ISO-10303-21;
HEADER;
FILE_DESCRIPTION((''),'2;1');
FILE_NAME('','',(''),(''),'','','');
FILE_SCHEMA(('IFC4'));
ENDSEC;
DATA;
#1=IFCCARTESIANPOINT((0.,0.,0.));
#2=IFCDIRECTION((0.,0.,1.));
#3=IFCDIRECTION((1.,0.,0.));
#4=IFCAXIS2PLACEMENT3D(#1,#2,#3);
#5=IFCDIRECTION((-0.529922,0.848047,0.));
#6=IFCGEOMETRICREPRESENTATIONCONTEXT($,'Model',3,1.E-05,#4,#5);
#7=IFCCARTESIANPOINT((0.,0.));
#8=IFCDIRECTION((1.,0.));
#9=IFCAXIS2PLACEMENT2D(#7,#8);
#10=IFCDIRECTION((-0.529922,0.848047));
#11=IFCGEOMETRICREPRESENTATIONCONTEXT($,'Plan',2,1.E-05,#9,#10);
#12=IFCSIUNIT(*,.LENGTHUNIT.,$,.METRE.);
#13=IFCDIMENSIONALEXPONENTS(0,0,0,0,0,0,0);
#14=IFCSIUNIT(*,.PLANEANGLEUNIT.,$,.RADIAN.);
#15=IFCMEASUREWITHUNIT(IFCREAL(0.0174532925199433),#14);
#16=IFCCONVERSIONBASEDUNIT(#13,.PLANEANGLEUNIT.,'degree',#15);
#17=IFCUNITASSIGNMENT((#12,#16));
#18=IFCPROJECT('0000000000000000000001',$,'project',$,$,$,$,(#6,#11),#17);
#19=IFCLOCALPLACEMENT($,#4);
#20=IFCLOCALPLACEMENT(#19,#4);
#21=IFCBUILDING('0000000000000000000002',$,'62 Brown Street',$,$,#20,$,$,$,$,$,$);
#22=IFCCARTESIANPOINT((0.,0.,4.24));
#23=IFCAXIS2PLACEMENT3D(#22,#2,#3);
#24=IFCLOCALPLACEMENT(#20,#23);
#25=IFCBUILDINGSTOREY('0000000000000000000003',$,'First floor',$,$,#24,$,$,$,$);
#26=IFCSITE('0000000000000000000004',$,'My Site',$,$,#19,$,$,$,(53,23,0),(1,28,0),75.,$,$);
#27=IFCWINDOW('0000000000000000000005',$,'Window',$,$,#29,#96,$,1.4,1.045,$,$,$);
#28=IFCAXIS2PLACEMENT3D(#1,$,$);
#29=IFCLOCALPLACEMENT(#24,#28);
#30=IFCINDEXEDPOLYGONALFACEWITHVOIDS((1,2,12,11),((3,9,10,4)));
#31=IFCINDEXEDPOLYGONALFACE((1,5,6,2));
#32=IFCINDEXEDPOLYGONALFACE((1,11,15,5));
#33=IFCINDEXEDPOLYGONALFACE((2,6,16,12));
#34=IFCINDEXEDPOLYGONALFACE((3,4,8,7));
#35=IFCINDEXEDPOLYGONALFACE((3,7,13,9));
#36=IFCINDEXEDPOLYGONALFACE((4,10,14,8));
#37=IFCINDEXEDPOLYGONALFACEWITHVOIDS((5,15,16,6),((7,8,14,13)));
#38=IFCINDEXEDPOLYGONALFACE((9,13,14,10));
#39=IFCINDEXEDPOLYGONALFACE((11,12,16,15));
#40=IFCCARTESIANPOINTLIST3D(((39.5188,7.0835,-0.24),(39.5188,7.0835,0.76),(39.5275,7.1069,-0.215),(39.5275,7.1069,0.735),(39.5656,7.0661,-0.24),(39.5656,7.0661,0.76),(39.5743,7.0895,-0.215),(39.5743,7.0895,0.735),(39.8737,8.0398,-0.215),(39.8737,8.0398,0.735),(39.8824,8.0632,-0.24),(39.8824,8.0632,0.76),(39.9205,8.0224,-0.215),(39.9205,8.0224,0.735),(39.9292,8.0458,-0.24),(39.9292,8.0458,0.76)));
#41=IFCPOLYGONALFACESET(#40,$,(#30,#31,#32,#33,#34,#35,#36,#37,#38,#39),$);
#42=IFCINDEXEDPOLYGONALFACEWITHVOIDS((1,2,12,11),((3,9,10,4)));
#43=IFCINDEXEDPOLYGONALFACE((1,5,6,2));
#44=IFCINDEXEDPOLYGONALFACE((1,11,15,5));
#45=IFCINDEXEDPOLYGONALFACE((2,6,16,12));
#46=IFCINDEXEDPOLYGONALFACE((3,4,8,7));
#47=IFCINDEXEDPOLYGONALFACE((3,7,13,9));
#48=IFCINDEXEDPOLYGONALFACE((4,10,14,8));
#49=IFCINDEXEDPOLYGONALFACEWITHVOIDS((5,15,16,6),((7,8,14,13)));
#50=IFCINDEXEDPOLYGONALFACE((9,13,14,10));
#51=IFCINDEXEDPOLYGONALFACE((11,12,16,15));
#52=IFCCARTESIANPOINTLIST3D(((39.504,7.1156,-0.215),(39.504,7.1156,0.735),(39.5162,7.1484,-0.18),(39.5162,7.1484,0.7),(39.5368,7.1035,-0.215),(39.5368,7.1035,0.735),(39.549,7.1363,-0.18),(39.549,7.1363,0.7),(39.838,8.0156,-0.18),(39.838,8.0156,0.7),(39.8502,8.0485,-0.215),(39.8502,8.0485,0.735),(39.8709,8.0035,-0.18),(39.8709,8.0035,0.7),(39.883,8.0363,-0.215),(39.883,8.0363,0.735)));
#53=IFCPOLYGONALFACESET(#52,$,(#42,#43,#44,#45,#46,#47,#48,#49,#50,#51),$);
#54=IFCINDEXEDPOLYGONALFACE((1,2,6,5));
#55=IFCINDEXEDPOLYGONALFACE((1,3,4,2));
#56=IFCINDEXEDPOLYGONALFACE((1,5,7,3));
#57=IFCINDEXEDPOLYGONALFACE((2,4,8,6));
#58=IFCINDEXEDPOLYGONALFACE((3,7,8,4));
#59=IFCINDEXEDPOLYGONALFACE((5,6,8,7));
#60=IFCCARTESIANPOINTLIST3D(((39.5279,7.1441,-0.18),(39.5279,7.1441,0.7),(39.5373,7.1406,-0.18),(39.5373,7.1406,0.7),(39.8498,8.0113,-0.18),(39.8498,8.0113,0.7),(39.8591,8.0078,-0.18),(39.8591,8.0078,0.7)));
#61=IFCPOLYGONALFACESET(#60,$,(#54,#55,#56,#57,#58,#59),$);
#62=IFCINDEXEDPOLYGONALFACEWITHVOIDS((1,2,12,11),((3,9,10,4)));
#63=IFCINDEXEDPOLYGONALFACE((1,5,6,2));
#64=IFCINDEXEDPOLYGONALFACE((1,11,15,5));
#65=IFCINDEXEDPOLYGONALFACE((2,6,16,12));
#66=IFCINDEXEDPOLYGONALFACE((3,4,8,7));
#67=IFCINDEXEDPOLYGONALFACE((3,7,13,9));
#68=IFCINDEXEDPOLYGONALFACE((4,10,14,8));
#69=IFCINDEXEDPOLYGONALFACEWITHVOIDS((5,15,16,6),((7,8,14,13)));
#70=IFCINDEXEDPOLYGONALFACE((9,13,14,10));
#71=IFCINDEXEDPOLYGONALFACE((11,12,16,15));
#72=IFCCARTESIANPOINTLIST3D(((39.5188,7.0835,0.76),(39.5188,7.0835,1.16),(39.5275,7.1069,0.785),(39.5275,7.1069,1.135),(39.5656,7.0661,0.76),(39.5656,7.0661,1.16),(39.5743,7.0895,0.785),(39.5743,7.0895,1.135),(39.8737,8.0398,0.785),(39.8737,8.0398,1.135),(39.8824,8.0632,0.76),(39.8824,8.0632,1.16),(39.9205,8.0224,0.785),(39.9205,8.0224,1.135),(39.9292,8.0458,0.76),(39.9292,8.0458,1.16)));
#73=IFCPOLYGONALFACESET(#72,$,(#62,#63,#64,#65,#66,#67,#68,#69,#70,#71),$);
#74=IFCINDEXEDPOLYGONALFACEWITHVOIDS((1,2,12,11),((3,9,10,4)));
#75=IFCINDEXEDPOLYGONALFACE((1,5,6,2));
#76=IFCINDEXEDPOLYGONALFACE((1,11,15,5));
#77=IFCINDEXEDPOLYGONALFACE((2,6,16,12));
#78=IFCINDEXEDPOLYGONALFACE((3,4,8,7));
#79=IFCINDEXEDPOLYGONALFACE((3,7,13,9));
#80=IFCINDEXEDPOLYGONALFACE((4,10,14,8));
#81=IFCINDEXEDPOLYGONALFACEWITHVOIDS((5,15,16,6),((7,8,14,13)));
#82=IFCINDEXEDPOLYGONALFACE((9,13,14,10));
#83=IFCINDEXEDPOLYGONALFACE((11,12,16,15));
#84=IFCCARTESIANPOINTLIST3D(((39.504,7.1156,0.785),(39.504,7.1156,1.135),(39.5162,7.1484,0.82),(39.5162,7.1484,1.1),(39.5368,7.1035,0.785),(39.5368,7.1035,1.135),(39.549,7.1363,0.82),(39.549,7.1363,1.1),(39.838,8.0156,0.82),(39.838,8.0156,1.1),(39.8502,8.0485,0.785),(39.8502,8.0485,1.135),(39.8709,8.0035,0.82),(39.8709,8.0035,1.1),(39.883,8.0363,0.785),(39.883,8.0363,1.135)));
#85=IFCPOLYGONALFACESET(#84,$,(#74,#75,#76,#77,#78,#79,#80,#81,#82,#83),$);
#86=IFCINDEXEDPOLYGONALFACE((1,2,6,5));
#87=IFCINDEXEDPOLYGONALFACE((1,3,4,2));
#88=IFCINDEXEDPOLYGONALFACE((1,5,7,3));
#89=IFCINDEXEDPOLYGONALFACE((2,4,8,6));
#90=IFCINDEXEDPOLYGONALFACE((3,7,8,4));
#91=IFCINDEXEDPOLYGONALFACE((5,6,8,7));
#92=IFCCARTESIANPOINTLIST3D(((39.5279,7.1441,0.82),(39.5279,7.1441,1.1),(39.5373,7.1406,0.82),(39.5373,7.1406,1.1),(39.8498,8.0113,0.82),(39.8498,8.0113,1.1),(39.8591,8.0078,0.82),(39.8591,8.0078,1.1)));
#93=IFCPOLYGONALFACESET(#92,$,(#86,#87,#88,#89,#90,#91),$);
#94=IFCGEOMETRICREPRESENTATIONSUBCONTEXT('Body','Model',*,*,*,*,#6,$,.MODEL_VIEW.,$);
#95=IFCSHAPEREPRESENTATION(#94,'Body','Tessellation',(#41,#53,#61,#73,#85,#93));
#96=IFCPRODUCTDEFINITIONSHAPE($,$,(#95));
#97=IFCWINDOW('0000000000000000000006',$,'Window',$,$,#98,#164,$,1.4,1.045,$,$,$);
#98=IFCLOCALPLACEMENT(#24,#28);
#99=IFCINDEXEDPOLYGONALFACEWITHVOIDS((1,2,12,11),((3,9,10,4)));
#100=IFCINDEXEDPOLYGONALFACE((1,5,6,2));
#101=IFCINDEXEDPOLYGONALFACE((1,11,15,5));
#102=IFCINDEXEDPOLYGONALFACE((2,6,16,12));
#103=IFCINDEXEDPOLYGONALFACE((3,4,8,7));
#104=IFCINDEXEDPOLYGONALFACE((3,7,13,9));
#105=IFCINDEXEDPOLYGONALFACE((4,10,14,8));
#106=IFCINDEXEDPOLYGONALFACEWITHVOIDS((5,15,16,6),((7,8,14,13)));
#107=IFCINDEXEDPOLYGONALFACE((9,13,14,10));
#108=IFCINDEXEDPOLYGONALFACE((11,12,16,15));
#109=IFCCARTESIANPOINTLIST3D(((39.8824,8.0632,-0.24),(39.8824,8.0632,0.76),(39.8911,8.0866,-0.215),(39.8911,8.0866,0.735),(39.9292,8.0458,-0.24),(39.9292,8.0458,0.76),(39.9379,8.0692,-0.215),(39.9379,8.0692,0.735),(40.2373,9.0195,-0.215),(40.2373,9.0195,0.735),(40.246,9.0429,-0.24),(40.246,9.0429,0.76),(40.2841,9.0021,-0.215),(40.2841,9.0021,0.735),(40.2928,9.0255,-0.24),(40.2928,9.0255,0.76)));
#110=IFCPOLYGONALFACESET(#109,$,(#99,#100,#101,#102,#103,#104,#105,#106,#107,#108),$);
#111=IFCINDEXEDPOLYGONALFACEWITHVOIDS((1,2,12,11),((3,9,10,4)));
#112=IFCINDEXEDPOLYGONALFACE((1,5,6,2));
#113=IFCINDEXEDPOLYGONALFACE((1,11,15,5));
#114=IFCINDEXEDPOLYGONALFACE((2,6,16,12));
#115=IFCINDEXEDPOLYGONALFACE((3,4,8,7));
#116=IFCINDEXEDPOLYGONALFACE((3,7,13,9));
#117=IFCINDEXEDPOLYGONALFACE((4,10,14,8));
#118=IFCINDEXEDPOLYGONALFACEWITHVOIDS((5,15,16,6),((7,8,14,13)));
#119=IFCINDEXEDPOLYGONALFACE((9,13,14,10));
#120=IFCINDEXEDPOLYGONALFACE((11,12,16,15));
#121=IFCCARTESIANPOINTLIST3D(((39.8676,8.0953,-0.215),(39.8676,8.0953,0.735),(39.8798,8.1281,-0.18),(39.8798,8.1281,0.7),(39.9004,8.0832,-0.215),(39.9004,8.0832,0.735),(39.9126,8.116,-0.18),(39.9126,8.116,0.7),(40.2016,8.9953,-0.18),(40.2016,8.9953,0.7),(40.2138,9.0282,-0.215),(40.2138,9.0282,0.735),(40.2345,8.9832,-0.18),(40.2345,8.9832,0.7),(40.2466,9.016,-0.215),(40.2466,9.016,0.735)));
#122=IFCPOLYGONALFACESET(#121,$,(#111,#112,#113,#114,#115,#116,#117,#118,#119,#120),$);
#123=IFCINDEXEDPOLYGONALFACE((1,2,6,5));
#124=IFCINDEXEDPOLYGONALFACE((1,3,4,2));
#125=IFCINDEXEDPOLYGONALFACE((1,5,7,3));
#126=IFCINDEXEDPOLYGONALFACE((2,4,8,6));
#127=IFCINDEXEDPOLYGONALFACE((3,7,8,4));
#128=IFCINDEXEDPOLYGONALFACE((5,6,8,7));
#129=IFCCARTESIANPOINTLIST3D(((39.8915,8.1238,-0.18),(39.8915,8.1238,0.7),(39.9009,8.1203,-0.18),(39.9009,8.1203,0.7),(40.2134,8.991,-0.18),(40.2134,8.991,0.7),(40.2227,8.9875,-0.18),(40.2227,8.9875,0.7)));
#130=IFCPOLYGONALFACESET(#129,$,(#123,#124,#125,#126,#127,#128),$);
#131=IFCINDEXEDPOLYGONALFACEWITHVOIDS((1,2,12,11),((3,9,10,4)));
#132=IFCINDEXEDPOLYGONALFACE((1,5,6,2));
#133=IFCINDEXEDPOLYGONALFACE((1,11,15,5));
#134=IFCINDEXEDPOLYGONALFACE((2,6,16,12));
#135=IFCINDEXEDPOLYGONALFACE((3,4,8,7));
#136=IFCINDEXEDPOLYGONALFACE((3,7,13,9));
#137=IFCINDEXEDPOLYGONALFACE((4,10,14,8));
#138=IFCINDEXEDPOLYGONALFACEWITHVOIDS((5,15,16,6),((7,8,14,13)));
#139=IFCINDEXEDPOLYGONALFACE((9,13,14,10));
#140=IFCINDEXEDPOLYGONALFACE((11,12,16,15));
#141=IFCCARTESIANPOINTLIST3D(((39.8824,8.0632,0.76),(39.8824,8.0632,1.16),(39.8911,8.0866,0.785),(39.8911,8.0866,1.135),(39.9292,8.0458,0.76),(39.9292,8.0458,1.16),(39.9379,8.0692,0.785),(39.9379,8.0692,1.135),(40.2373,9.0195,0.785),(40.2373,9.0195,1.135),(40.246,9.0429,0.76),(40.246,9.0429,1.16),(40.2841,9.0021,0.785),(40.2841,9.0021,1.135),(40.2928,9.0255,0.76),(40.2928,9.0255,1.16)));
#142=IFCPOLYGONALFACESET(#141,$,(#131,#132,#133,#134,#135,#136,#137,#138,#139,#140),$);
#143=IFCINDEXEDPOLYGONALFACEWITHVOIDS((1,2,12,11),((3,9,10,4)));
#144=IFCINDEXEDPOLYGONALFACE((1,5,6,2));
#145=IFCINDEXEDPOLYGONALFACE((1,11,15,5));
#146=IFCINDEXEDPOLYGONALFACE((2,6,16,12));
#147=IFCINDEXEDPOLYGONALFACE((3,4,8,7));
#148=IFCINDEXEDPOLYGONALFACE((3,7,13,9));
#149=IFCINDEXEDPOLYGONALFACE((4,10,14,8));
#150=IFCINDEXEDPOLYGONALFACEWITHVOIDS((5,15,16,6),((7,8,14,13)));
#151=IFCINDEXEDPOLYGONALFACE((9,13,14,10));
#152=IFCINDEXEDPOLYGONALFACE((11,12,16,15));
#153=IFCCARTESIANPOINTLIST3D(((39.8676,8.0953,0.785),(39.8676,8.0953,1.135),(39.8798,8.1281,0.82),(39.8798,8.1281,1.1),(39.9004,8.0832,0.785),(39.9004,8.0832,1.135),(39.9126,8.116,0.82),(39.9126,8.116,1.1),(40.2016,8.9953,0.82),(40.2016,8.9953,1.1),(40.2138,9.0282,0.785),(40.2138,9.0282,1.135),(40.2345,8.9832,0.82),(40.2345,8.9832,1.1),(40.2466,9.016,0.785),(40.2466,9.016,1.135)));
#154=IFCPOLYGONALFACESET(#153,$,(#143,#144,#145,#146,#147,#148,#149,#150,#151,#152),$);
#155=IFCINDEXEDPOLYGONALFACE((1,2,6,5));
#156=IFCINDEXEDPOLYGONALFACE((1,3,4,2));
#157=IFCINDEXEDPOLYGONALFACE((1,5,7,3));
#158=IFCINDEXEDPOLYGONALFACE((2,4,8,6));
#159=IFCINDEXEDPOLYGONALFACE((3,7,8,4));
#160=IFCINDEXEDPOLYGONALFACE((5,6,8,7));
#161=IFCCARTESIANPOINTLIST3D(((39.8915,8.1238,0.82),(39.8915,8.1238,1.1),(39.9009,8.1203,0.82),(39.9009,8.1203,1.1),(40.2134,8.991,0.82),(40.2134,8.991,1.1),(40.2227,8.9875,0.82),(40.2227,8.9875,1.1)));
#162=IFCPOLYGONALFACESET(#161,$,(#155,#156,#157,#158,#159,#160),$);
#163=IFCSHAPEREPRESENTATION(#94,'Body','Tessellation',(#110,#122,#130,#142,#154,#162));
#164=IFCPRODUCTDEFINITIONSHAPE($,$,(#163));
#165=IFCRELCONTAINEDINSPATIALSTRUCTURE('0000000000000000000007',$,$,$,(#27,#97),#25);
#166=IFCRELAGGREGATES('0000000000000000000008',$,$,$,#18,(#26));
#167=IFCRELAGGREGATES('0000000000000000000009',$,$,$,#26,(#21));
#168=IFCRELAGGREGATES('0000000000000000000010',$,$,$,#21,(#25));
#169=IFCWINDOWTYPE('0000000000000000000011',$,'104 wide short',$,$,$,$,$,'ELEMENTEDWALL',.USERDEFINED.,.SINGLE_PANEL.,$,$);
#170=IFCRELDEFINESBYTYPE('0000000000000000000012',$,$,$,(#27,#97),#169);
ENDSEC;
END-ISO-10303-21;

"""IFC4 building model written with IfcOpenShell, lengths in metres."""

from ifc_helpers import new_model, entity, si_unit, converted_unit, direction, frame, origin_with_axes, origin_2d_with_axis, place, context, subcontext, project, spatial, line, indexed_curve, outline, extrude, shape, source, transform, mapped, type_object, type_shapes, element, save


model = new_model("IFC4")

# Units and contexts
model_context = context("Model", 3, precision=1e-05, world=origin_with_axes(), true_north=direction((-0.529922, 0.848047, 0.0)))
plan_context = context("Plan", 2, precision=1e-05, world=origin_2d_with_axis(), true_north=direction((-0.529922, 0.848047)))
body_context_1 = subcontext(model_context, "Body", "Model", "MODEL_VIEW")
body_context_2 = subcontext(plan_context, "Body", "Plan", "PLAN_VIEW")
ifc_project = project(units=[si_unit("LENGTHUNIT", "METRE"), converted_unit("PLANEANGLEUNIT", "degree", entity("IfcReal", 0.0174532925199433), si_unit("PLANEANGLEUNIT", "RADIAN"), dimensions=[0, 0, 0, 0, 0, 0, 0])], contexts=[model_context, plan_context])

# Site, building, storey
site_placement = place(None, origin_with_axes())
site = spatial("IfcSite", under=ifc_project, at=site_placement, Name="My Site", RefLatitude=(53, 23, 0), RefLongitude=(1, 28, 0), RefElevation=75.0)
building_placement = place(site_placement, origin_with_axes())
building = spatial("IfcBuilding", under=site, at=building_placement, Name="62 Brown Street")
storey_placement = place(building_placement, frame((0.0, 0.0, 4.24), z_axis=(0.0, 0.0, 1.0), x_axis=(1.0, 0.0, 0.0)))
storey = spatial("IfcBuildingStorey", under=building, at=storey_placement, Name="First floor")

# Shared definitions
window_type = type_object("IfcWindowType", Name="104 wide short", ElementType="ELEMENTEDWALL", PartitioningType="SINGLE_PANEL", PredefinedType="USERDEFINED")
shared_shape_1 = source(origin_with_axes(), body_context_1, "Body", "SweptSolid", [
    extrude(outline(indexed_curve([(0.0, 0.0), (1.045, 0.0), (1.045, 1.0), (0.0, 1.0)], segments=[line(1, 2, 3, 4, 1)]), holes=[indexed_curve([(0.025, 0.025), (1.02, 0.025), (1.02, 0.975), (0.025, 0.975)], segments=[line(1, 2, 3, 4, 1)])]), frame((0.0, 0.15, 0.0), z_axis=(0.0, -1.0, 0.0), x_axis=(1.0, 0.0, 0.0)), (0.0, 0.0, -1.0), 0.05),
    extrude(outline(indexed_curve([(0.0, 0.0), (0.995, 0.0), (0.995, 0.95), (0.0, 0.95)], segments=[line(1, 2, 3, 4, 1)]), holes=[indexed_curve([(0.035, 0.035), (0.96, 0.035), (0.96, 0.915), (0.035, 0.915)], segments=[line(1, 2, 3, 4, 1)])]), frame((0.025, 0.19, 0.025), z_axis=(0.0, -1.0, 0.0), x_axis=(1.0, 0.0, 0.0)), (0.0, 0.0, -1.0), 0.035),
    extrude(outline(indexed_curve([(0.035, 0.035), (0.96, 0.035), (0.96, 0.915), (0.035, 0.915)], segments=[line(1, 2, 3, 4, 1)])), frame((0.025, 0.2025, 0.025), z_axis=(0.0, -1.0, 0.0), x_axis=(1.0, 0.0, 0.0)), (0.0, 0.0, -1.0), 0.01),
    extrude(outline(indexed_curve([(0.0, 0.0), (1.045, 0.0), (1.045, 0.4), (0.0, 0.4)], segments=[line(1, 2, 3, 4, 1)]), holes=[indexed_curve([(0.025, 0.025), (1.02, 0.025), (1.02, 0.375), (0.025, 0.375)], segments=[line(1, 2, 3, 4, 1)])]), frame((0.0, 0.15, 1.0), z_axis=(0.0, -1.0, 0.0), x_axis=(1.0, 0.0, 0.0)), (0.0, 0.0, -1.0), 0.05),
    extrude(outline(indexed_curve([(0.0, 0.0), (0.995, 0.0), (0.995, 0.35), (0.0, 0.35)], segments=[line(1, 2, 3, 4, 1)]), holes=[indexed_curve([(0.035, 0.035), (0.96, 0.035), (0.96, 0.315), (0.035, 0.315)], segments=[line(1, 2, 3, 4, 1)])]), frame((0.025, 0.19, 1.025), z_axis=(0.0, -1.0, 0.0), x_axis=(1.0, 0.0, 0.0)), (0.0, 0.0, -1.0), 0.035),
    extrude(outline(indexed_curve([(0.035, 0.035), (0.96, 0.035), (0.96, 0.315), (0.035, 0.315)], segments=[line(1, 2, 3, 4, 1)])), frame((0.025, 0.2025, 1.025), z_axis=(0.0, -1.0, 0.0), x_axis=(1.0, 0.0, 0.0)), (0.0, 0.0, -1.0), 0.01),
])
shared_shape_2 = source(origin_with_axes(), body_context_2, "Body", "Curve2D", [
    entity("IfcIndexedPolyCurve", entity("IfcCartesianPointList2D", [[0.025, 0.15], [1.02, 0.15]])),
    entity("IfcIndexedPolyCurve", entity("IfcCartesianPointList2D", [[0.0, 0.2], [0.025, 0.2], [0.025, 0.15], [0.0, 0.15]]), [entity("IfcLineIndex", [1, 2, 3, 4, 1])]),
    entity("IfcIndexedPolyCurve", entity("IfcCartesianPointList2D", [[1.045, 0.2], [1.02, 0.2], [1.02, 0.15], [1.045, 0.15]]), [entity("IfcLineIndex", [1, 2, 3, 4, 1])]),
    entity("IfcIndexedPolyCurve", entity("IfcCartesianPointList2D", [[0.025, 0.19], [0.06, 0.19], [0.06, 0.225], [0.025, 0.225]]), [entity("IfcLineIndex", [1, 2, 3, 4, 1])]),
    entity("IfcIndexedPolyCurve", entity("IfcCartesianPointList2D", [[1.02, 0.19], [0.985, 0.19], [0.985, 0.225], [1.02, 0.225]]), [entity("IfcLineIndex", [1, 2, 3, 4, 1])]),
    entity("IfcIndexedPolyCurve", entity("IfcCartesianPointList2D", [[0.06, 0.19], [0.985, 0.19]])),
    entity("IfcIndexedPolyCurve", entity("IfcCartesianPointList2D", [[0.06, 0.225], [0.985, 0.225]])),
    entity("IfcIndexedPolyCurve", entity("IfcCartesianPointList2D", [[0.06, 0.2075], [0.985, 0.2075]])),
])
type_shapes(window_type, [shared_shape_1, shared_shape_2])

# Windows
for number, where, z_axis, x_axis, name in (
    (1, (39.7063, 7.0139, -0.24), (0.0, 0.0, 1.0), (0.347944, 0.937515, 0.0), "Window"),
    (2, (40.0699, 7.9936, -0.24), (0.0, 0.0, 1.0), (0.347944, 0.937515, 0.0), "Window"),
):
    element("IfcWindow", number, at=place(storey_placement, frame(where, z_axis=z_axis, x_axis=x_axis)), inside=storey, type_object=window_type, Name=name, OverallHeight=1.4, OverallWidth=1.045, shapes=[
        shape(body_context_1, "Body", "MappedRepresentation", [mapped(shared_shape_1, transform((0.0, 0.0, 0.0), x_axis=(1.0, 0.0, 0.0), y_axis=(0.0, 1.0, 0.0), z_axis=(0.0, 0.0, 1.0), scale=1.0))]),
        shape(body_context_2, "Body", "MappedRepresentation", [mapped(shared_shape_2, transform((0.0, 0.0, 0.0), x_axis=(1.0, 0.0, 0.0), y_axis=(0.0, 1.0, 0.0), z_axis=(0.0, 0.0, 1.0), scale=1.0))]),
    ])

save(model, "model.ifc")
